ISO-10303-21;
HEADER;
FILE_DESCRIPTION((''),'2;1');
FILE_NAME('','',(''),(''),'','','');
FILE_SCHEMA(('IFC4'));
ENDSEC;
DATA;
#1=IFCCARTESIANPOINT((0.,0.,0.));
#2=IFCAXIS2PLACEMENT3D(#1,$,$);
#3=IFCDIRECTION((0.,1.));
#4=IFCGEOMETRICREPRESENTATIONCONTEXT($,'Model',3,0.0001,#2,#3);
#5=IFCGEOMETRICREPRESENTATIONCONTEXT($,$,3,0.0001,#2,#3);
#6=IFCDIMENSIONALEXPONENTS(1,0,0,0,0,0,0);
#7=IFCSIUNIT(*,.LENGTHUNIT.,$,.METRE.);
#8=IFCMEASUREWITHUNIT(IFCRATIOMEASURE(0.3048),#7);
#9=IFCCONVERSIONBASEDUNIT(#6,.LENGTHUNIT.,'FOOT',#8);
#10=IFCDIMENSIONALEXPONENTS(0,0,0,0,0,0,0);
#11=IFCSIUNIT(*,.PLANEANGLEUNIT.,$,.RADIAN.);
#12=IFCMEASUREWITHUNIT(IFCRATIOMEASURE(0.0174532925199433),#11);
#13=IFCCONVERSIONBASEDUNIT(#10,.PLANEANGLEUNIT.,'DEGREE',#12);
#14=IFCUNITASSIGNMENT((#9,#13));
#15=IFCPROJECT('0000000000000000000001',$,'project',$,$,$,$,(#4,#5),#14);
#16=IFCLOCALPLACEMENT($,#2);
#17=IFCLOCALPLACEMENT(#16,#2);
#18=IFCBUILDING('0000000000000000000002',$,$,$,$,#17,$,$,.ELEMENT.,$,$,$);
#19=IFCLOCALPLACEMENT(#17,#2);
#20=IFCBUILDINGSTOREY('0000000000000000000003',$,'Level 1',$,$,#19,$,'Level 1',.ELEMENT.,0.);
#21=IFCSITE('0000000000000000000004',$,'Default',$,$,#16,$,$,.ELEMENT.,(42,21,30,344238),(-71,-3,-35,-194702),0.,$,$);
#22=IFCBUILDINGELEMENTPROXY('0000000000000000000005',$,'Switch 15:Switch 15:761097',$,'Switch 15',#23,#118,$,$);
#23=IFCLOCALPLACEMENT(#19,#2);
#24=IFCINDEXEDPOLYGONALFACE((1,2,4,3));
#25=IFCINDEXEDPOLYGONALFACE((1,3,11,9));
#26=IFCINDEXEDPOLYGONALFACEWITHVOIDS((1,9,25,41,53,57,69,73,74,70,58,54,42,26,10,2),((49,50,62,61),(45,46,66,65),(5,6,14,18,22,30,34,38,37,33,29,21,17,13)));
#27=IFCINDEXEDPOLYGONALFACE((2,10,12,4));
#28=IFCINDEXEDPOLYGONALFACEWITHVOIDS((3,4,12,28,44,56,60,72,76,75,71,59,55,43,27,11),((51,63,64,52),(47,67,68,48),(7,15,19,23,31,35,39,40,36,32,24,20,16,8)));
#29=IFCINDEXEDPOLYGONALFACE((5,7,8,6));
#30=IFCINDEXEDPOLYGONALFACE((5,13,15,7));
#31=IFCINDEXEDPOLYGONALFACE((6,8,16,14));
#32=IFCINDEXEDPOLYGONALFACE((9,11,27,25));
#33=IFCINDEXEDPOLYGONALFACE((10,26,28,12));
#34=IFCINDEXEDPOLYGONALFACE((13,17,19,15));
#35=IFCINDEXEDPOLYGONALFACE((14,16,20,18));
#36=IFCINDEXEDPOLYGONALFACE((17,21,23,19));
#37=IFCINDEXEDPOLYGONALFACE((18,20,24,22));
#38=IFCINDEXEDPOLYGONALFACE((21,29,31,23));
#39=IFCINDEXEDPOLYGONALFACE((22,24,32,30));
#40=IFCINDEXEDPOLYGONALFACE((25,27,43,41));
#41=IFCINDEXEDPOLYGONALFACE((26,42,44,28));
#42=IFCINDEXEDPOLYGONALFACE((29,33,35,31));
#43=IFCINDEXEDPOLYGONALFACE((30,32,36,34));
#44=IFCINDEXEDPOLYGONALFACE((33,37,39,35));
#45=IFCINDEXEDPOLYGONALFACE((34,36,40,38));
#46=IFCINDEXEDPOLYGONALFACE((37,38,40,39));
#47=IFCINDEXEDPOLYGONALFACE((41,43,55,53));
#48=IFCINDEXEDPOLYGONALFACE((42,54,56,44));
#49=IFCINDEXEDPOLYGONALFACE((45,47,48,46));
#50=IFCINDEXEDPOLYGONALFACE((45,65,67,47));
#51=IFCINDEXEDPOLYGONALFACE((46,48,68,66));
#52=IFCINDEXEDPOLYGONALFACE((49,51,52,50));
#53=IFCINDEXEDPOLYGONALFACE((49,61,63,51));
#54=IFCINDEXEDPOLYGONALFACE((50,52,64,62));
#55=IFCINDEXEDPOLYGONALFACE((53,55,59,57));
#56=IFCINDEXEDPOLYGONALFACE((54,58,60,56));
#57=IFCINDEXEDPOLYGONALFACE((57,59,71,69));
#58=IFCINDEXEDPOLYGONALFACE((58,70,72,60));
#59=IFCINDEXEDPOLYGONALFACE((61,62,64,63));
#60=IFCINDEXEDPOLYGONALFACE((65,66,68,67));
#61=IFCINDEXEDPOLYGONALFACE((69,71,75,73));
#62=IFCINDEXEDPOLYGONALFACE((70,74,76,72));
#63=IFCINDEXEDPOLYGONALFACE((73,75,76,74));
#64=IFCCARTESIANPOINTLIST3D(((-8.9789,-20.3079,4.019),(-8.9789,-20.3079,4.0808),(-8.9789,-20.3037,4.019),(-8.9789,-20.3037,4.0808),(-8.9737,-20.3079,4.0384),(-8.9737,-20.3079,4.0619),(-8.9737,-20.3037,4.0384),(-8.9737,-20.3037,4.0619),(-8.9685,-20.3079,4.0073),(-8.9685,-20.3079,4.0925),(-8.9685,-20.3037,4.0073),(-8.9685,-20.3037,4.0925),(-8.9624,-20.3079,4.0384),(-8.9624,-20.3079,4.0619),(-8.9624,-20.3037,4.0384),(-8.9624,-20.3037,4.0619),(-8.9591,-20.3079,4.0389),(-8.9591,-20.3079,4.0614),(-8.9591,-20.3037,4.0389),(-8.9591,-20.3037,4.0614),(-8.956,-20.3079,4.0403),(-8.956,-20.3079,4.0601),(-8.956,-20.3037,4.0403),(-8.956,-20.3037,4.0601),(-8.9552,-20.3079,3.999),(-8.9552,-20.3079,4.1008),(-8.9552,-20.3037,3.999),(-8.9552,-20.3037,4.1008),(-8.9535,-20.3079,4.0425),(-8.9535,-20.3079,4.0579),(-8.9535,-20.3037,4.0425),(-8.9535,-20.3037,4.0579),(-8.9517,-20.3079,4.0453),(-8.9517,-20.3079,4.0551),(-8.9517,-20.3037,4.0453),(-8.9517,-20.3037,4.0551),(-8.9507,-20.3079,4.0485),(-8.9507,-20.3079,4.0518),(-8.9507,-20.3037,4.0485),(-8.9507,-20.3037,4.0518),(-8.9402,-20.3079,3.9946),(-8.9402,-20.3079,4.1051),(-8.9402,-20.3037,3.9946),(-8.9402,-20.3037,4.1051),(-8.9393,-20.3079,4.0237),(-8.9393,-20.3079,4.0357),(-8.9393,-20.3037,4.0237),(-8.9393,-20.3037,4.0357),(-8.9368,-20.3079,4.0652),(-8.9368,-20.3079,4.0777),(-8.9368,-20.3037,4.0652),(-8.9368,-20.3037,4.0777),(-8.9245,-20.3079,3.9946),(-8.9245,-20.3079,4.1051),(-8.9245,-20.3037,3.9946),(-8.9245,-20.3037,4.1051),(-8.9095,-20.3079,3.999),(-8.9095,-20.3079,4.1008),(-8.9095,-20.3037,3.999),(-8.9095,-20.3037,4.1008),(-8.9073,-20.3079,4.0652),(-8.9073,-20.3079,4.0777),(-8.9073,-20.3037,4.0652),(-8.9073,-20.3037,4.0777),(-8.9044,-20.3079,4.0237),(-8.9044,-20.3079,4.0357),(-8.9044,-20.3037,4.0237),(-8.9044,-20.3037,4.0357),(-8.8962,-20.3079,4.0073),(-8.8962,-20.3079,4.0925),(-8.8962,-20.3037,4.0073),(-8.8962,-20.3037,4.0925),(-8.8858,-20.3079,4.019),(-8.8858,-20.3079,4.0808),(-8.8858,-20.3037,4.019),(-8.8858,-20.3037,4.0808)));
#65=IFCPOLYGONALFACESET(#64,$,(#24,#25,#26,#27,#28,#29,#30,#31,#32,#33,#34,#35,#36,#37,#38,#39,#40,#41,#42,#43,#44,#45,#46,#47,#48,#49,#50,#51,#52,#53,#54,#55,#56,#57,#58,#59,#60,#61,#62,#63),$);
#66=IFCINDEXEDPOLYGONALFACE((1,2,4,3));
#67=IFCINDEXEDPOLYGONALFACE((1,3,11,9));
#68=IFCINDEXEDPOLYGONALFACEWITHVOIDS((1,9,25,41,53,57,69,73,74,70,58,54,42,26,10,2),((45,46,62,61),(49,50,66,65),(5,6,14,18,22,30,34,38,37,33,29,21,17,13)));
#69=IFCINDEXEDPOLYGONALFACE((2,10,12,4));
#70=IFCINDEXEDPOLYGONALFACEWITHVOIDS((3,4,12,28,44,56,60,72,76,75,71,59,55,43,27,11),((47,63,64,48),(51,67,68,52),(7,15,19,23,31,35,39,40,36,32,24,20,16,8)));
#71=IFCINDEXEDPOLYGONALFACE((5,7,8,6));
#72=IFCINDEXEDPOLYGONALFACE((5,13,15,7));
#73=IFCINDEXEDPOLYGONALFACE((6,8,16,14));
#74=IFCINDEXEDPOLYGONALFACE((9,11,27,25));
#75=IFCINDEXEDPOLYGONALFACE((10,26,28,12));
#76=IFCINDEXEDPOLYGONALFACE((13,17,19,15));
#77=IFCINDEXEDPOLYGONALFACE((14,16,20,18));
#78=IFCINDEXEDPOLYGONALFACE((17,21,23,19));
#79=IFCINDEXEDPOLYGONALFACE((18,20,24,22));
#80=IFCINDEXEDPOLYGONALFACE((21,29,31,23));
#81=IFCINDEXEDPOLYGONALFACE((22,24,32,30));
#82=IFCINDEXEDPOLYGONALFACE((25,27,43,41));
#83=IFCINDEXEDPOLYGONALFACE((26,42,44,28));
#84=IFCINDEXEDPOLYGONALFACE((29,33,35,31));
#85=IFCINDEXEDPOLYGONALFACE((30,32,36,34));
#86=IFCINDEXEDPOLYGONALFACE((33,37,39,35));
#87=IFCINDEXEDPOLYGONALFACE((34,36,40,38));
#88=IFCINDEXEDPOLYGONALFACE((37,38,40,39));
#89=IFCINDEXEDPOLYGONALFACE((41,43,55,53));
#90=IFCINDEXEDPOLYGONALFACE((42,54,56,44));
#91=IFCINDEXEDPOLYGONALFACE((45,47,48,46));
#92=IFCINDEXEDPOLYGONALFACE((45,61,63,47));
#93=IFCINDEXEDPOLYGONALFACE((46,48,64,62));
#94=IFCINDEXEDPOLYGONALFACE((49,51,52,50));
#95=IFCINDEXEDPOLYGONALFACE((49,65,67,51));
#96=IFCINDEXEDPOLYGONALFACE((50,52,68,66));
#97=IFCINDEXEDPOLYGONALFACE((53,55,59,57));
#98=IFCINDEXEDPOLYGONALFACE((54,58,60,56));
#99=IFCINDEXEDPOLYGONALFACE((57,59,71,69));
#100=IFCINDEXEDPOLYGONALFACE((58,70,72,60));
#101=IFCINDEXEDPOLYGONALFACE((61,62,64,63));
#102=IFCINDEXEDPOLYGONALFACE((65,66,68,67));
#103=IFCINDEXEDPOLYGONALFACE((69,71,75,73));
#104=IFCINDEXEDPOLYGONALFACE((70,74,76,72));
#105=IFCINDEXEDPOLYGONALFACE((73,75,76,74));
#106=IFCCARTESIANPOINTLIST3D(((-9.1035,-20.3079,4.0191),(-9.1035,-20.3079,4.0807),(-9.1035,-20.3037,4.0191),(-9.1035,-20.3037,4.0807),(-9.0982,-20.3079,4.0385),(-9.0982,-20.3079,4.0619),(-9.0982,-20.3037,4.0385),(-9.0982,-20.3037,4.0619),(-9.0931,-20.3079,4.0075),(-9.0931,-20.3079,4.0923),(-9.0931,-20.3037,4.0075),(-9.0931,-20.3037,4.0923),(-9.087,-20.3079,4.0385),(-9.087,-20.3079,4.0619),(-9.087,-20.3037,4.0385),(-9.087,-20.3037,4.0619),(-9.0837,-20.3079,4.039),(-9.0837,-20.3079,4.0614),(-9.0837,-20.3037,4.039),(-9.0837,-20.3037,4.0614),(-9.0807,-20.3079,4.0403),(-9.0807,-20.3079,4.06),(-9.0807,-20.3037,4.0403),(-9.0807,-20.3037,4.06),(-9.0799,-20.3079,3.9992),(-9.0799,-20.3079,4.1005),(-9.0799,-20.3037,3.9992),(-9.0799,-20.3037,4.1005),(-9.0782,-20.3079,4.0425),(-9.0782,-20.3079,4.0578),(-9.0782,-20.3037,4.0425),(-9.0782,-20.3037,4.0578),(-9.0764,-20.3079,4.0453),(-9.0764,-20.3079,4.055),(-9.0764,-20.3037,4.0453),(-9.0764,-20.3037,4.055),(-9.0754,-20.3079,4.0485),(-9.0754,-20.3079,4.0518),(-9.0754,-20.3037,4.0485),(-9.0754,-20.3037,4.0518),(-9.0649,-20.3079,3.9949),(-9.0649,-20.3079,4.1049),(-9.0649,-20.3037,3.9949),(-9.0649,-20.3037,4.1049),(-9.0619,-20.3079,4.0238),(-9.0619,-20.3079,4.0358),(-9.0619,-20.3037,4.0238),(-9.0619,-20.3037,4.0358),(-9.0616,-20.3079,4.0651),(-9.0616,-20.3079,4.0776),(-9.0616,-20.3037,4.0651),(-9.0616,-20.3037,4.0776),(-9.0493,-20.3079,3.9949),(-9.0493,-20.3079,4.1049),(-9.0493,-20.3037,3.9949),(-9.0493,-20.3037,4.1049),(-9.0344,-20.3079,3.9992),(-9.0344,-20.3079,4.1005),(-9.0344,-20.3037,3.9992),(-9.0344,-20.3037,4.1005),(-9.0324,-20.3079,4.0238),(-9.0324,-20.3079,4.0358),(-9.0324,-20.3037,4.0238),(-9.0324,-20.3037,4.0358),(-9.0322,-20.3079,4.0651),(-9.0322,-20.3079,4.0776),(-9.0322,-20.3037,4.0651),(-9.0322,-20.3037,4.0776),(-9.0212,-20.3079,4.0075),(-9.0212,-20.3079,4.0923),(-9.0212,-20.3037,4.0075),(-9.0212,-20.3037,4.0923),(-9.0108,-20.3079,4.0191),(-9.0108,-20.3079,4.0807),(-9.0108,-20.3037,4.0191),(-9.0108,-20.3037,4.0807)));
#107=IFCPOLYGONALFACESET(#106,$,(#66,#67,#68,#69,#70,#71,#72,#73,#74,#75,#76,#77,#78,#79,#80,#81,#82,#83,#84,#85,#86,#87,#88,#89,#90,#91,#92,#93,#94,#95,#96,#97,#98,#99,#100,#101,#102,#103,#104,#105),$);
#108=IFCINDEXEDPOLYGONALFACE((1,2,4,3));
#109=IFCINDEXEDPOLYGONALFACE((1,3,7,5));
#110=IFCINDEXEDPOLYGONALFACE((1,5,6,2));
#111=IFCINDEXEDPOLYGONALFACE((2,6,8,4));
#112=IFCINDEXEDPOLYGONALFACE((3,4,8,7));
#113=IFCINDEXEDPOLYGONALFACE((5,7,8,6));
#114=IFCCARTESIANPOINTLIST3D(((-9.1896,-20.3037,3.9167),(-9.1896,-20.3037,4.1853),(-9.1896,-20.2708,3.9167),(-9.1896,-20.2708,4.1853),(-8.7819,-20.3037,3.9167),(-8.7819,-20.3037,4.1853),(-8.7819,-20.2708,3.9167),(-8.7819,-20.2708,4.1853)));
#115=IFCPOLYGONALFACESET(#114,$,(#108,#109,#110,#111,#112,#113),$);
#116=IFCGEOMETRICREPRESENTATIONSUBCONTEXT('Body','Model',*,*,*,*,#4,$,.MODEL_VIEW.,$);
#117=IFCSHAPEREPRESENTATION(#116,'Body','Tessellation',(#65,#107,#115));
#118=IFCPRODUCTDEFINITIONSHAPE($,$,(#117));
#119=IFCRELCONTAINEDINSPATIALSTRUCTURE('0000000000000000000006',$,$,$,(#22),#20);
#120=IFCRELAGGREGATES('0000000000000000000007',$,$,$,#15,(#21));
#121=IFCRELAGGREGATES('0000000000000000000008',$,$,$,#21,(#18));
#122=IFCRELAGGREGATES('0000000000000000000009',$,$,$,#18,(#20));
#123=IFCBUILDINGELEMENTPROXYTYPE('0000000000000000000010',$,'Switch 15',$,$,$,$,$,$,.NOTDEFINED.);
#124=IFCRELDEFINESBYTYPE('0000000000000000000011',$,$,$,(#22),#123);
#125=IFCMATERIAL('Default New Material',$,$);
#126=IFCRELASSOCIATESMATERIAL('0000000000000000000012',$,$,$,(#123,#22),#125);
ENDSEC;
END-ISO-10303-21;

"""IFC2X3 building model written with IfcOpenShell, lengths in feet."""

from ifc_helpers import new_model, entity, si_unit, converted_unit, direction, frame, frame_2d, origin, origin_2d_with_axis, place, context, subcontext, project, spatial, polyline, circle_curve, parameter, trimmed, segment, composite_curve, rectangle, outline, extrude, source, transform, mapped, material, type_object, type_shapes, element, save


model = new_model("IFC2X3")

# Units and contexts
model_context = context("Model", 3, precision=0.0001, world=origin(), true_north=direction((0.0, 1.0)))
context_of_model = context(None, 3, precision=0.0001, world=origin(), true_north=direction((0.0, 1.0)))
body_context = subcontext(model_context, "Body", "Model", "MODEL_VIEW")
ifc_project = project(units=[converted_unit("LENGTHUNIT", "FOOT", entity("IfcRatioMeasure", 0.3048), si_unit("LENGTHUNIT", "METRE"), dimensions=[1, 0, 0, 0, 0, 0, 0]), converted_unit("PLANEANGLEUNIT", "DEGREE", entity("IfcRatioMeasure", 0.0174532925199433), si_unit("PLANEANGLEUNIT", "RADIAN"), dimensions=[0, 0, 0, 0, 0, 0, 0])], contexts=[model_context, context_of_model])

# Site, building, storey
site_placement = place(None, origin())
site = spatial("IfcSite", under=ifc_project, at=site_placement, Name="Default", CompositionType="ELEMENT", RefLatitude=(42, 21, 30, 344238), RefLongitude=(-71, -3, -35, -194702), RefElevation=0.0)
building_placement = place(site_placement, origin())
building = spatial("IfcBuilding", under=site, at=building_placement, CompositionType="ELEMENT")
storey_placement = place(building_placement, origin())
storey = spatial("IfcBuildingStorey", under=building, at=storey_placement, Name="Level 1", LongName="Level 1", CompositionType="ELEMENT", Elevation=0.0)

# Shared definitions
ifc_material_1 = material(Name="Default New Material")

# Building element proxy
building_element_proxy_type_1 = type_object("IfcBuildingElementProxyType", Name="Switch 15", PredefinedType="NOTDEFINED", material=ifc_material_1)
shared_shape_1 = source(origin(), body_context, "Body", "SweptSolid", [
    extrude(outline(composite_curve([segment(polyline([(-0.0309, -0.0466), (0.0309, -0.0466)]), True, "CONTINUOUS"), segment(trimmed(circle_curve(frame_2d((-0.0003, 0.0), x_axis=(-1.0, 0.0)), 0.0561), [parameter(123.794741)], [parameter(236.205259)], True, "PARAMETER"), True, "CONTINUOUS"), segment(polyline([(0.0309, 0.0466), (-0.0309, 0.0466)]), True, "CONTINUOUS"), segment(trimmed(circle_curve(frame_2d((0.0003, 0.0), x_axis=(1.0, 0.0)), 0.0561), [parameter(123.794741)], [parameter(236.205259)], True, "PARAMETER"), True, "CONTINUOUS")], self_intersect=False), holes=[polyline([(0.0142, 0.0279), (0.0262, 0.0279), (0.0262, -0.0069), (0.0142, -0.0069), (0.0142, 0.0279)]), polyline([(-0.0153, 0.025), (-0.0153, -0.0045), (-0.0278, -0.0045), (-0.0278, 0.025), (-0.0153, 0.025)]), composite_curve([segment(polyline([(-0.012, -0.0413), (-0.012, -0.03)]), True, "CONTINUOUS"), segment(trimmed(circle_curve(frame_2d((-0.0003, -0.03), x_axis=(-1.0, 0.0)), 0.0117), [parameter(180.0)], [parameter(0.0)], True, "PARAMETER"), False, "CONTINUOUS"), segment(polyline([(0.0115, -0.03), (0.0115, -0.0413)]), True, "CONTINUOUS"), segment(polyline([(0.0115, -0.0413), (-0.012, -0.0413)]), True, "CONTINUOUS")], self_intersect=False)]), frame((-0.0534, 0.0329, 0.1332), z_axis=(0.0, 1.0, 0.0), x_axis=(0.0, 0.0, -1.0)), (0.0, 0.0, 1.0), 0.0042),
    extrude(outline(composite_curve([segment(polyline([(-0.0308, -0.0464), (0.0308, -0.0464)]), True, "CONTINUOUS"), segment(trimmed(circle_curve(frame_2d((-0.0003, 0.0), x_axis=(-1.0, 0.0)), 0.0558), [parameter(123.794741)], [parameter(236.205259)], True, "PARAMETER"), True, "CONTINUOUS"), segment(polyline([(0.0308, 0.0464), (-0.0308, 0.0464)]), True, "CONTINUOUS"), segment(trimmed(circle_curve(frame_2d((0.0003, 0.0), x_axis=(1.0, 0.0)), 0.0558), [parameter(123.794741)], [parameter(236.205259)], True, "PARAMETER"), True, "CONTINUOUS")], self_intersect=False), holes=[polyline([(0.0141, 0.0247), (0.026, 0.0247), (0.026, -0.0047), (0.0141, -0.0047), (0.0141, 0.0247)]), polyline([(-0.0152, 0.0249), (-0.0152, -0.0045), (-0.0277, -0.0045), (-0.0277, 0.0249), (-0.0152, 0.0249)]), composite_curve([segment(polyline([(-0.012, -0.0411), (-0.012, -0.0299)]), True, "CONTINUOUS"), segment(trimmed(circle_curve(frame_2d((-0.0003, -0.0299), x_axis=(-1.0, 0.0)), 0.0117), [parameter(180.0)], [parameter(0.0)], True, "PARAMETER"), False, "CONTINUOUS"), segment(polyline([(0.0114, -0.0299), (0.0114, -0.0411)]), True, "CONTINUOUS"), segment(polyline([(0.0114, -0.0411), (-0.012, -0.0411)]), True, "CONTINUOUS")], self_intersect=False)]), frame((0.0714, 0.0329, 0.1332), z_axis=(0.0, 1.0, 0.0), x_axis=(0.0, 0.0, -1.0)), (0.0, 0.0, 1.0), 0.0042),
    extrude(rectangle(XDim=0.0329, YDim=0.4078, at=origin_2d_with_axis()), frame((0.0, 0.0164, 0.0), z_axis=(0.0, 0.0, 1.0), x_axis=(0.0, -1.0, 0.0)), (0.0, 0.0, 1.0), 0.2687),
])
type_shapes(building_element_proxy_type_1, [shared_shape_1])
proxy_1_placement = place(storey_placement, frame((-8.9857, -20.2708, 3.9167), z_axis=(0.0, 0.0, 1.0), x_axis=(-1.0, 0.0, 0.0)))
element("IfcBuildingElementProxy", 1, at=proxy_1_placement, inside=storey, type_object=building_element_proxy_type_1, material=ifc_material_1, Name="Switch 15:Switch 15:761097", ObjectType="Switch 15", context=body_context, shape_type="MappedRepresentation", body=[
    mapped(shared_shape_1, transform((0.0, 0.0, 0.0), scale=1.0)),
])

save(model, "model.ifc")
